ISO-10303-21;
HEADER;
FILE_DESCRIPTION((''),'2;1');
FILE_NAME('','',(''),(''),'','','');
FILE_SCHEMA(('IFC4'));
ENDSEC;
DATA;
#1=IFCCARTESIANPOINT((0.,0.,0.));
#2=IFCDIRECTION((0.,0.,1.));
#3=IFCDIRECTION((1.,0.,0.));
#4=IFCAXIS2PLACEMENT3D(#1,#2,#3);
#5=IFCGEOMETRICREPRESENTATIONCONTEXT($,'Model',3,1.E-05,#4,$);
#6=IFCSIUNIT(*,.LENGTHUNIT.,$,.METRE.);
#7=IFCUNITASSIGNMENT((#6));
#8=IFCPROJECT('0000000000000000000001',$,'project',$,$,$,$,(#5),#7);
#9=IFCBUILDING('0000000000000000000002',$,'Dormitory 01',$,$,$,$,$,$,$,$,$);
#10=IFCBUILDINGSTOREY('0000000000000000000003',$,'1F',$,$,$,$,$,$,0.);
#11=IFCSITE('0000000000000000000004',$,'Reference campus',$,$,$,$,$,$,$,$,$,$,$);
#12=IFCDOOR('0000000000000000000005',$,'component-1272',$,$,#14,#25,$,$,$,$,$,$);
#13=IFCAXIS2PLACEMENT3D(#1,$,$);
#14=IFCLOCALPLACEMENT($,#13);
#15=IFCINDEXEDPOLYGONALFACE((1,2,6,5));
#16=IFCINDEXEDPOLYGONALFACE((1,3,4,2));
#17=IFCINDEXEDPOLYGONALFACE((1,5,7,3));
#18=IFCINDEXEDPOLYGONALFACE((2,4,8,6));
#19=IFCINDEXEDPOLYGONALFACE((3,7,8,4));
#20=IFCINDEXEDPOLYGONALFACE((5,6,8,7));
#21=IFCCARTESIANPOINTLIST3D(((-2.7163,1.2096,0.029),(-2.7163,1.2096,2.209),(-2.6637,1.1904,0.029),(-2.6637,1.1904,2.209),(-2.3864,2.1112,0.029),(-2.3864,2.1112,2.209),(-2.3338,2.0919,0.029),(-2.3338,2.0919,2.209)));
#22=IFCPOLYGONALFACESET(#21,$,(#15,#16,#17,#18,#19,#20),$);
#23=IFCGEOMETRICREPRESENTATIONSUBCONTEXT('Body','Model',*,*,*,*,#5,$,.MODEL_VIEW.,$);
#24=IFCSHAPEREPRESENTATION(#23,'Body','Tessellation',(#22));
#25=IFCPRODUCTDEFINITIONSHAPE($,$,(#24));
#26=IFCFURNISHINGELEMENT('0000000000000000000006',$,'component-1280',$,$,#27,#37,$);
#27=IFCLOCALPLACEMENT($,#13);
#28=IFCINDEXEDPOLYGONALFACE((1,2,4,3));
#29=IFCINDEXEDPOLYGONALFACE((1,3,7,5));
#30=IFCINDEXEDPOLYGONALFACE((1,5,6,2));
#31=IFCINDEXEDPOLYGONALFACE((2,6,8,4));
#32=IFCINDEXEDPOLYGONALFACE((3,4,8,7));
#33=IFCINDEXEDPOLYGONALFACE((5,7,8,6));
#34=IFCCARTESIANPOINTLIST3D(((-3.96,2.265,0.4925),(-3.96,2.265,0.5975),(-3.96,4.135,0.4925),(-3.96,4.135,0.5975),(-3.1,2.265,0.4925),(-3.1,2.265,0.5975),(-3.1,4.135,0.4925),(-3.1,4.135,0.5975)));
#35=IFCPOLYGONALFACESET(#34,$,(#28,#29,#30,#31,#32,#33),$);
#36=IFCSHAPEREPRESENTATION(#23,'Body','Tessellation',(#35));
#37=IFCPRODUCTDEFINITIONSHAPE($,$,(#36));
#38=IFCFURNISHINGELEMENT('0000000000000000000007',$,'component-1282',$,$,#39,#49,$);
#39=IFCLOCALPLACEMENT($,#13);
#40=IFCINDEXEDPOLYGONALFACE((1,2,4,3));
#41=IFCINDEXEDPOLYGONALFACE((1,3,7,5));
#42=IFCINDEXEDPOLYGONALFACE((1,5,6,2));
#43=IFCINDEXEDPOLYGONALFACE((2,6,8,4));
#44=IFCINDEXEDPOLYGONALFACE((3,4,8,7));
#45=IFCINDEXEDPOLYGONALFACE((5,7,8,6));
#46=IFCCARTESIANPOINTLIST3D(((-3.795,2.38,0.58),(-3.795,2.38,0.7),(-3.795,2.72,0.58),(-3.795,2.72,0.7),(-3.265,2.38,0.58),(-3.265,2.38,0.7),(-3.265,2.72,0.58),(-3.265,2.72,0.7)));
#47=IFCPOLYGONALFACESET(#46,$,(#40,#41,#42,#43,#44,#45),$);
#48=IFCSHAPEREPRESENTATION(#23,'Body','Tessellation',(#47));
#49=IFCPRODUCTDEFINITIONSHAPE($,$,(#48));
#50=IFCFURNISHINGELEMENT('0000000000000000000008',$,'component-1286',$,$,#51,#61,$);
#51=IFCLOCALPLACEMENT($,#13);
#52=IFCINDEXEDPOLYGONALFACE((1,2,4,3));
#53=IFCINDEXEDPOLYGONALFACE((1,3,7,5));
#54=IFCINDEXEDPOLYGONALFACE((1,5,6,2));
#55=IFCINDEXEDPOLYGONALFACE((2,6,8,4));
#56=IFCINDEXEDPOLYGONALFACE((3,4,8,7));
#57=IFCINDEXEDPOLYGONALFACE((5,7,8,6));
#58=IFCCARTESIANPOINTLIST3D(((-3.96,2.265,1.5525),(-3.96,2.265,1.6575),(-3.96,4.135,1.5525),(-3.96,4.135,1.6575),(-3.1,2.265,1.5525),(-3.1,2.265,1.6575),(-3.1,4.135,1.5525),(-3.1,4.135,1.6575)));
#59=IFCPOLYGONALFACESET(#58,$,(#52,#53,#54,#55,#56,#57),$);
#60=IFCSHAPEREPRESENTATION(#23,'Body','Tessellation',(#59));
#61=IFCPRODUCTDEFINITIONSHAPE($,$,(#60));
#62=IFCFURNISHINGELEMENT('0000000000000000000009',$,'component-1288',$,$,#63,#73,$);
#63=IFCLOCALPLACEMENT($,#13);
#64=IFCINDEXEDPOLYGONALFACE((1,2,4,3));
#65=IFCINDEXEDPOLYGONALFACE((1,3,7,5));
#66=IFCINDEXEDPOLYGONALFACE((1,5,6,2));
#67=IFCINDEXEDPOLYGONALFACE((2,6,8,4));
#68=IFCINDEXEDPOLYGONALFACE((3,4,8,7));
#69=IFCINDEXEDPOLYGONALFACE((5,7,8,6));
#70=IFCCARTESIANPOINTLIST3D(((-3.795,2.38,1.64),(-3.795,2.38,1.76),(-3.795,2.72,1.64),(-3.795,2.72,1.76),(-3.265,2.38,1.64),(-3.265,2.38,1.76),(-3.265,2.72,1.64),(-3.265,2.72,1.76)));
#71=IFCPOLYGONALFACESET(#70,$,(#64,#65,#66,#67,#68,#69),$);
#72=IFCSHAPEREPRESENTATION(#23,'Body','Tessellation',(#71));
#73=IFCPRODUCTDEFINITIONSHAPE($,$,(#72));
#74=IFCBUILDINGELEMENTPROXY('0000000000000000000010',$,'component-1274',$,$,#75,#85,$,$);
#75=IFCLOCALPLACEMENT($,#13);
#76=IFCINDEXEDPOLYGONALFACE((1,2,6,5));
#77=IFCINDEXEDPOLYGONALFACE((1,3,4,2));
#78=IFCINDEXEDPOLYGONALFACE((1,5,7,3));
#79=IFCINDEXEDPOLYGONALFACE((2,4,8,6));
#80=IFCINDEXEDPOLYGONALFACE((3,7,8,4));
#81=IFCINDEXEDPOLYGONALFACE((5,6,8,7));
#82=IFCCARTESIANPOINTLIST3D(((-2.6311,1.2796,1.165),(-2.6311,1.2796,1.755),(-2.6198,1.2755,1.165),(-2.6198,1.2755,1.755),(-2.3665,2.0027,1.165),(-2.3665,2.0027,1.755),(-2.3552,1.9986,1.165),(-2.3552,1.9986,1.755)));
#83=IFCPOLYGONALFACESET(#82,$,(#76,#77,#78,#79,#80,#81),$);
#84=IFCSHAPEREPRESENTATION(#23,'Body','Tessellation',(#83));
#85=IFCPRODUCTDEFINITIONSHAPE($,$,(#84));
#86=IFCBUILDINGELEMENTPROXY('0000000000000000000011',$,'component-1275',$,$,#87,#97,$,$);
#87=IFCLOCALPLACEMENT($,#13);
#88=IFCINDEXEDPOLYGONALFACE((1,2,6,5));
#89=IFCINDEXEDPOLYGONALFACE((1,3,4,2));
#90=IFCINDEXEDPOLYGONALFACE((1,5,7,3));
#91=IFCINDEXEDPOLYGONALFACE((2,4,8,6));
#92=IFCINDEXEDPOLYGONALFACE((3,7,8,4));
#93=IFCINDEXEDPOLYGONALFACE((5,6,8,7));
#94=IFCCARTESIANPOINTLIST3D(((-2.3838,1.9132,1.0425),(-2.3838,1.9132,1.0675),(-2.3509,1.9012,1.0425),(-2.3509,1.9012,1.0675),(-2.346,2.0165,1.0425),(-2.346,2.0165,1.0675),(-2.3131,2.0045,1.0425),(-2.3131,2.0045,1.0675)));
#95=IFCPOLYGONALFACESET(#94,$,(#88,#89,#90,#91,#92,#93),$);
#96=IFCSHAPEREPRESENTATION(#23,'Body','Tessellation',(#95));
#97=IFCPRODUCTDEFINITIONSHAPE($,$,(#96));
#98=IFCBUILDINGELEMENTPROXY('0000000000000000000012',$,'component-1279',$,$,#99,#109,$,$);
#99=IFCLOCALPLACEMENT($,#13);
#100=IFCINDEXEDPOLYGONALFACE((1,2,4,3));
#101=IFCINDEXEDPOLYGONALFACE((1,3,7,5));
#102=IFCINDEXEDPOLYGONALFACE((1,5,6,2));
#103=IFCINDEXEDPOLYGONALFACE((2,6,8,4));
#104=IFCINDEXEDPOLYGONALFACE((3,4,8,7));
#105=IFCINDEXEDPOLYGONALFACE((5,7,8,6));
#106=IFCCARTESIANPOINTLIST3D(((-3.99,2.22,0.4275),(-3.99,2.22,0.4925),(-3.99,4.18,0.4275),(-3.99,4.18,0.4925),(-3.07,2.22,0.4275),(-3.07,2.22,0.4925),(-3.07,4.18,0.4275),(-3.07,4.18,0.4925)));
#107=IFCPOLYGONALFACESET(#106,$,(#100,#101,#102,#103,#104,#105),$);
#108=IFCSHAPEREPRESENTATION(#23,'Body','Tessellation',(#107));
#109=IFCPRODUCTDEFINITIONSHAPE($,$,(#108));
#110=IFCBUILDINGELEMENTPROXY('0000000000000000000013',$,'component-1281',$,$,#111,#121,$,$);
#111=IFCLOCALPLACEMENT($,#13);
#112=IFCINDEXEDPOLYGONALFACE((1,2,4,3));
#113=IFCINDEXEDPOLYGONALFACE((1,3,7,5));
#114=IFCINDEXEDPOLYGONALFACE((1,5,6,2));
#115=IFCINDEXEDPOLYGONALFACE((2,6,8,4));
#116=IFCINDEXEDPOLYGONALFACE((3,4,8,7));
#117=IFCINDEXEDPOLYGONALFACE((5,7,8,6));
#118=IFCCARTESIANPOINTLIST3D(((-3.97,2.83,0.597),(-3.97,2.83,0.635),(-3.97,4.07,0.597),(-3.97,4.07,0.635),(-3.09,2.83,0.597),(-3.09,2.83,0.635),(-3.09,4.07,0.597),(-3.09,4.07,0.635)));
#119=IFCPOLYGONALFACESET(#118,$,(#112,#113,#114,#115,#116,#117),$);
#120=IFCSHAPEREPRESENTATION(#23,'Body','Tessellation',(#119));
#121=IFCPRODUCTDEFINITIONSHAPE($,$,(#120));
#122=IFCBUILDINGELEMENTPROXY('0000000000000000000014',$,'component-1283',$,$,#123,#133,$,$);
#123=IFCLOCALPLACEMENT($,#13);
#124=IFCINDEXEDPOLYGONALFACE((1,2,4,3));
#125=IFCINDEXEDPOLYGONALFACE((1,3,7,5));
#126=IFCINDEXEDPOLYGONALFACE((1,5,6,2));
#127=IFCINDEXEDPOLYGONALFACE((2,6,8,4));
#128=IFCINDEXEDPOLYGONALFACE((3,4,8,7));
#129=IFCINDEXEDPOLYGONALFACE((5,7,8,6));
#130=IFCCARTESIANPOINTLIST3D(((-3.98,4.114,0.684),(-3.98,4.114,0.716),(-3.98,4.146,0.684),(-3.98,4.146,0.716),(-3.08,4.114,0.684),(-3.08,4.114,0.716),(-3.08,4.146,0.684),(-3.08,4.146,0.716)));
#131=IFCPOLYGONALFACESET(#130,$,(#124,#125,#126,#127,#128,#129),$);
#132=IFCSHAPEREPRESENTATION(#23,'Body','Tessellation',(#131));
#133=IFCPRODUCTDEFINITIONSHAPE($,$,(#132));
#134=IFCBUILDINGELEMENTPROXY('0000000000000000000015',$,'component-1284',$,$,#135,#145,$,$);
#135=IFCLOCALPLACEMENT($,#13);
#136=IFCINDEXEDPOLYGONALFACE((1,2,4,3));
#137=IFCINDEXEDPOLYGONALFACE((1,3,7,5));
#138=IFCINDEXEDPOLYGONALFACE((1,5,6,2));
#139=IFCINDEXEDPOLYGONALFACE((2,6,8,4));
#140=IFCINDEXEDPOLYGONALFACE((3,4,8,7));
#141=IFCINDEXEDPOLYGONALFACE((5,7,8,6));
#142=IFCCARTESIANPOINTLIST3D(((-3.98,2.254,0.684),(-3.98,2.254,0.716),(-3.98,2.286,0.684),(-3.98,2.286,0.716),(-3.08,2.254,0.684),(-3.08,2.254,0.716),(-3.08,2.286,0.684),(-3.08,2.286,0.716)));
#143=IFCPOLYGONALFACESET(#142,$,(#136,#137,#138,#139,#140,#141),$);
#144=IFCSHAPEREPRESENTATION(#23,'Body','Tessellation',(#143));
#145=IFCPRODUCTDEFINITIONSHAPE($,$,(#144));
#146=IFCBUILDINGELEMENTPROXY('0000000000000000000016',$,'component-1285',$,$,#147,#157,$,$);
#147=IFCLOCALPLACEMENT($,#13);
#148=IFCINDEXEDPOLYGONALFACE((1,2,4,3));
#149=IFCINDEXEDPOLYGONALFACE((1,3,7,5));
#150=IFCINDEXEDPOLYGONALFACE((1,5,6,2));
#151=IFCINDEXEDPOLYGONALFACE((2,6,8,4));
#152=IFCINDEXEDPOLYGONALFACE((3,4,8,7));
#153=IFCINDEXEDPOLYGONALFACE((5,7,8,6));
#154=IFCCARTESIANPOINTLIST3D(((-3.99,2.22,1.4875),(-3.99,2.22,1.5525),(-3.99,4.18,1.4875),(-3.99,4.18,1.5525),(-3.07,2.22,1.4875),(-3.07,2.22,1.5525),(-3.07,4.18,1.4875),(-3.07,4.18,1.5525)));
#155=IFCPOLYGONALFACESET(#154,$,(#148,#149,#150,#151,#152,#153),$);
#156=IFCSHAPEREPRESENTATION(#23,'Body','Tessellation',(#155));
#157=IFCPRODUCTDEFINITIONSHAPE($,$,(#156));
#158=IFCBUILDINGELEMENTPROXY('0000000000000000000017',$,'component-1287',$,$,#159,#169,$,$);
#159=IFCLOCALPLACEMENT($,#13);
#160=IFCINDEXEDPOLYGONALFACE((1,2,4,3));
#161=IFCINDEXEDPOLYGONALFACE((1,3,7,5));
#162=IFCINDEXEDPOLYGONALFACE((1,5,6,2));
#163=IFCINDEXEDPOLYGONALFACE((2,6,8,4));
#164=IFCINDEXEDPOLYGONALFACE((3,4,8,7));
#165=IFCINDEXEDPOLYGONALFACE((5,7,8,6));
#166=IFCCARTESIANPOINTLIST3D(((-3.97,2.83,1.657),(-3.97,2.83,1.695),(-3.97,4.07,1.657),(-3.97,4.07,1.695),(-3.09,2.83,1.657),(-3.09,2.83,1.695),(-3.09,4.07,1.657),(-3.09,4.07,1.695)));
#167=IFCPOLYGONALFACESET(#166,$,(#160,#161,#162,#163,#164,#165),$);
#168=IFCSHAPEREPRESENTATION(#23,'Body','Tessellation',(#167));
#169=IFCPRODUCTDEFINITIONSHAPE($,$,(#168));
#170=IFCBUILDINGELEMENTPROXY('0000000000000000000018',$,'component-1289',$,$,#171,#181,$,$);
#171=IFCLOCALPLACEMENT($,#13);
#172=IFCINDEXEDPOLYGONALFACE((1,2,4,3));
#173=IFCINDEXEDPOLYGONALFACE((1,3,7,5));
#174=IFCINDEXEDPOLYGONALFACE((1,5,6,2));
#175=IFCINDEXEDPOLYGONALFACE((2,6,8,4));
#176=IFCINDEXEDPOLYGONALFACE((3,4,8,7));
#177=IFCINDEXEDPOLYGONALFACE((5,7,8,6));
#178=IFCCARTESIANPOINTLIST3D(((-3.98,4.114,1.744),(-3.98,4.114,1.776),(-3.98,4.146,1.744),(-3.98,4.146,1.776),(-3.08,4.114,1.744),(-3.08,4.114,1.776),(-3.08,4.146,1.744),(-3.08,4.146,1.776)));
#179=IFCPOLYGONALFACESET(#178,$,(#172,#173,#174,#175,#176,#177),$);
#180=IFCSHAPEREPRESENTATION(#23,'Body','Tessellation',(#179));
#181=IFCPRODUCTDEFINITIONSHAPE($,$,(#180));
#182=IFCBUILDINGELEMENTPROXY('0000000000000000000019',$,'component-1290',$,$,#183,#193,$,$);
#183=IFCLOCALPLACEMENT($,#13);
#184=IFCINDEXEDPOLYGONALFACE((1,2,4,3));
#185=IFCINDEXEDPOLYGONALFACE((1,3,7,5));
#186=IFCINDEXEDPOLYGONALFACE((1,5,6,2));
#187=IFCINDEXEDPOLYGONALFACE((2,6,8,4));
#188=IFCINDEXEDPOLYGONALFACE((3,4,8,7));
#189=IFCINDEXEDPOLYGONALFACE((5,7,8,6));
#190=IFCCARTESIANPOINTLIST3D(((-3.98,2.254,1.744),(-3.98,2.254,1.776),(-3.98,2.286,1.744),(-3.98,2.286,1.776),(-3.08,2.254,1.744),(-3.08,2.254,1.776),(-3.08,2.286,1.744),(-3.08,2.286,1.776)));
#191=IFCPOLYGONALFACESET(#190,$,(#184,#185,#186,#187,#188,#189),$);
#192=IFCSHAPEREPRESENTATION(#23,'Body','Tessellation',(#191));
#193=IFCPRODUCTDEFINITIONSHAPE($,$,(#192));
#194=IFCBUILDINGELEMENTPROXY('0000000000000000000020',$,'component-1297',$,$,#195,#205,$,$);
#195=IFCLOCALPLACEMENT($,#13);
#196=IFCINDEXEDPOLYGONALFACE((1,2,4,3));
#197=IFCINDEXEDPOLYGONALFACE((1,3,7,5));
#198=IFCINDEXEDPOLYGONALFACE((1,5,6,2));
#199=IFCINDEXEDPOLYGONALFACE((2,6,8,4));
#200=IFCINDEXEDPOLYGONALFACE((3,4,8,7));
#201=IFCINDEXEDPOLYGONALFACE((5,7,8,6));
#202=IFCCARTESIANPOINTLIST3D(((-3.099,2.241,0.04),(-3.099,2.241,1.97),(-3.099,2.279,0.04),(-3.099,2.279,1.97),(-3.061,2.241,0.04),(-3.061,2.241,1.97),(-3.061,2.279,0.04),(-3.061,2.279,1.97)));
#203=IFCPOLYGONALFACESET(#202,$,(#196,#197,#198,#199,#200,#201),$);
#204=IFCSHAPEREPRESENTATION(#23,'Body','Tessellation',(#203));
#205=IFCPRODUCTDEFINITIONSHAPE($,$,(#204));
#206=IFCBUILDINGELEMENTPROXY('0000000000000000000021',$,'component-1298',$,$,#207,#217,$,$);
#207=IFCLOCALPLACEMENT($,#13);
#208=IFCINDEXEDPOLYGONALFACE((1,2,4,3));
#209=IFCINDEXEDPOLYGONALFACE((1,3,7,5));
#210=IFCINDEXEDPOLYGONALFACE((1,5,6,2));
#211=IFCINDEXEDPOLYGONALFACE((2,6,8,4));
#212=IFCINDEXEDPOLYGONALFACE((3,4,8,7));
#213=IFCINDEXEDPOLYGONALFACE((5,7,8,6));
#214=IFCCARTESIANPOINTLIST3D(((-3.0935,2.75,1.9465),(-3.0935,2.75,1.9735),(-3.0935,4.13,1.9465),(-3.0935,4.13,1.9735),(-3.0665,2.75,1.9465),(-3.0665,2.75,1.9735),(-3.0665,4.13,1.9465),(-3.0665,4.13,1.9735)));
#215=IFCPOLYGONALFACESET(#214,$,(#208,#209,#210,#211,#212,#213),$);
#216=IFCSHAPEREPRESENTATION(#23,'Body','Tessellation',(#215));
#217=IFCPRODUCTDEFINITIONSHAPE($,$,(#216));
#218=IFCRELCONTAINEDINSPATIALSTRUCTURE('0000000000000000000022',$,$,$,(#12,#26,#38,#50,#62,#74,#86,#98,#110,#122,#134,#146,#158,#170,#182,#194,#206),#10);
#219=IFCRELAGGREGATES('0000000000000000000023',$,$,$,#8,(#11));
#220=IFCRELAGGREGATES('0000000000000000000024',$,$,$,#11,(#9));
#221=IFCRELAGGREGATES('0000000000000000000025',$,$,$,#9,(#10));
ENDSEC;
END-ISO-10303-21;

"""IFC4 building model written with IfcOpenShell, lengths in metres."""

from ifc_helpers import new_model, si_unit, frame, origin, origin_with_axes, origin_2d, place, context, subcontext, project, spatial, rectangle, extrude, element, save


model = new_model("IFC4")

# Units and contexts
model_context = context("Model", 3, precision=1e-05, world=origin_with_axes())
body_context = subcontext(model_context, "Body", "Model", "MODEL_VIEW")
ifc_project = project(units=[si_unit("LENGTHUNIT", "METRE")], contexts=[model_context])

# Site, building, storey
site = spatial("IfcSite", under=ifc_project, Name="Reference campus")
building = spatial("IfcBuilding", under=site, Name="Dormitory 01")
storey = spatial("IfcBuildingStorey", under=building, Name="1F", Elevation=0.0)

# Door
door_placement = place(None, frame((-2.5251, 1.6508, 0.029), z_axis=(0.0, 0.0, 1.0), x_axis=(0.343646, 0.939099, 0.0)))
element("IfcDoor", 1, at=door_placement, inside=storey, Name="component-1272", context=body_context, shape_type="SweptSolid", body=[
    extrude(rectangle(XDim=0.96, YDim=0.056, at=origin_2d()), origin(), (0.0, 0.0, 1.0), 2.18),
])

# Furnishing elements
furnishing_1_placement = place(None, frame((-3.53, 3.2, 0.4925), z_axis=(0.0, 0.0, 1.0), x_axis=(1.0, 0.0, 0.0)))
element("IfcFurnishingElement", 2, at=furnishing_1_placement, inside=storey, Name="component-1280", context=body_context, shape_type="SweptSolid", body=[
    extrude(rectangle(XDim=0.86, YDim=1.87, at=origin_2d()), origin(), (0.0, 0.0, 1.0), 0.105),
])
furnishing_2_placement = place(None, frame((-3.53, 2.55, 0.58), z_axis=(0.0, 0.0, 1.0), x_axis=(1.0, 0.0, 0.0)))
element("IfcFurnishingElement", 3, at=furnishing_2_placement, inside=storey, Name="component-1282", context=body_context, shape_type="SweptSolid", body=[
    extrude(rectangle(XDim=0.53, YDim=0.34, at=origin_2d()), origin(), (0.0, 0.0, 1.0), 0.12),
])
furnishing_3_placement = place(None, frame((-3.53, 3.2, 1.5525), z_axis=(0.0, 0.0, 1.0), x_axis=(1.0, 0.0, 0.0)))
element("IfcFurnishingElement", 4, at=furnishing_3_placement, inside=storey, Name="component-1286", context=body_context, shape_type="SweptSolid", body=[
    extrude(rectangle(XDim=0.86, YDim=1.87, at=origin_2d()), origin(), (0.0, 0.0, 1.0), 0.105),
])
furnishing_4_placement = place(None, frame((-3.53, 2.55, 1.64), z_axis=(0.0, 0.0, 1.0), x_axis=(1.0, 0.0, 0.0)))
element("IfcFurnishingElement", 5, at=furnishing_4_placement, inside=storey, Name="component-1288", context=body_context, shape_type="SweptSolid", body=[
    extrude(rectangle(XDim=0.53, YDim=0.34, at=origin_2d()), origin(), (0.0, 0.0, 1.0), 0.12),
])

# Building element proxies
proxy_1_placement = place(None, frame((-2.4931, 1.6391, 1.165), z_axis=(0.0, 0.0, 1.0), x_axis=(0.343646, 0.939099, 0.0)))
element("IfcBuildingElementProxy", 6, at=proxy_1_placement, inside=storey, Name="component-1274", context=body_context, shape_type="SweptSolid", body=[
    extrude(rectangle(XDim=0.77, YDim=0.012, at=origin_2d()), origin(), (0.0, 0.0, 1.0), 0.59),
])
proxy_2_placement = place(None, frame((-2.3484, 1.9588, 1.0425), z_axis=(0.0, 0.0, 1.0), x_axis=(0.343646, 0.939099, 0.0)))
element("IfcBuildingElementProxy", 7, at=proxy_2_placement, inside=storey, Name="component-1275", context=body_context, shape_type="SweptSolid", body=[
    extrude(rectangle(XDim=0.11, YDim=0.035, at=origin_2d()), origin(), (0.0, 0.0, 1.0), 0.025),
])
proxy_3_placement = place(None, frame((-3.53, 3.2, 0.4275), z_axis=(0.0, 0.0, 1.0), x_axis=(1.0, 0.0, 0.0)))
element("IfcBuildingElementProxy", 8, at=proxy_3_placement, inside=storey, Name="component-1279", context=body_context, shape_type="SweptSolid", body=[
    extrude(rectangle(XDim=0.92, YDim=1.96, at=origin_2d()), origin(), (0.0, 0.0, 1.0), 0.065),
])
proxy_4_placement = place(None, frame((-3.53, 3.45, 0.597), z_axis=(0.0, 0.0, 1.0), x_axis=(1.0, 0.0, 0.0)))
element("IfcBuildingElementProxy", 9, at=proxy_4_placement, inside=storey, Name="component-1281", context=body_context, shape_type="SweptSolid", body=[
    extrude(rectangle(XDim=0.88, YDim=1.24, at=origin_2d()), origin(), (0.0, 0.0, 1.0), 0.038),
])
for number, where, z_axis, x_axis, name in (
    (10, (-3.53, 4.13, 0.684), (0.0, 0.0, 1.0), (1.0, 0.0, 0.0), "component-1283"),
    (11, (-3.53, 2.27, 0.684), (0.0, 0.0, 1.0), (1.0, 0.0, 0.0), "component-1284"),
):
    element("IfcBuildingElementProxy", number, at=place(None, frame(where, z_axis=z_axis, x_axis=x_axis)), inside=storey, Name=name, context=body_context, shape_type="SweptSolid", body=[
        extrude(rectangle(XDim=0.9, YDim=0.032, at=origin_2d()), origin(), (0.0, 0.0, 1.0), 0.032),
    ])
proxy_5_placement = place(None, frame((-3.53, 3.2, 1.4875), z_axis=(0.0, 0.0, 1.0), x_axis=(1.0, 0.0, 0.0)))
element("IfcBuildingElementProxy", 12, at=proxy_5_placement, inside=storey, Name="component-1285", context=body_context, shape_type="SweptSolid", body=[
    extrude(rectangle(XDim=0.92, YDim=1.96, at=origin_2d()), origin(), (0.0, 0.0, 1.0), 0.065),
])
proxy_6_placement = place(None, frame((-3.53, 3.45, 1.657), z_axis=(0.0, 0.0, 1.0), x_axis=(1.0, 0.0, 0.0)))
element("IfcBuildingElementProxy", 13, at=proxy_6_placement, inside=storey, Name="component-1287", context=body_context, shape_type="SweptSolid", body=[
    extrude(rectangle(XDim=0.88, YDim=1.24, at=origin_2d()), origin(), (0.0, 0.0, 1.0), 0.038),
])
for number, where, z_axis, x_axis, name in (
    (14, (-3.53, 4.13, 1.744), (0.0, 0.0, 1.0), (1.0, 0.0, 0.0), "component-1289"),
    (15, (-3.53, 2.27, 1.744), (0.0, 0.0, 1.0), (1.0, 0.0, 0.0), "component-1290"),
):
    element("IfcBuildingElementProxy", number, at=place(None, frame(where, z_axis=z_axis, x_axis=x_axis)), inside=storey, Name=name, context=body_context, shape_type="SweptSolid", body=[
        extrude(rectangle(XDim=0.9, YDim=0.032, at=origin_2d()), origin(), (0.0, 0.0, 1.0), 0.032),
    ])
proxy_7_placement = place(None, frame((-3.08, 2.26, 0.04), z_axis=(0.0, 0.0, 1.0), x_axis=(1.0, 0.0, 0.0)))
element("IfcBuildingElementProxy", 16, at=proxy_7_placement, inside=storey, Name="component-1297", context=body_context, shape_type="SweptSolid", body=[
    extrude(rectangle(XDim=0.038, YDim=0.038, at=origin_2d()), origin(), (0.0, 0.0, 1.0), 1.93),
])
proxy_8_placement = place(None, frame((-3.08, 3.44, 1.9465), z_axis=(0.0, 0.0, 1.0), x_axis=(1.0, 0.0, 0.0)))
element("IfcBuildingElementProxy", 17, at=proxy_8_placement, inside=storey, Name="component-1298", context=body_context, shape_type="SweptSolid", body=[
    extrude(rectangle(XDim=0.027, YDim=1.38, at=origin_2d()), origin(), (0.0, 0.0, 1.0), 0.027),
])

save(model, "model.ifc")
